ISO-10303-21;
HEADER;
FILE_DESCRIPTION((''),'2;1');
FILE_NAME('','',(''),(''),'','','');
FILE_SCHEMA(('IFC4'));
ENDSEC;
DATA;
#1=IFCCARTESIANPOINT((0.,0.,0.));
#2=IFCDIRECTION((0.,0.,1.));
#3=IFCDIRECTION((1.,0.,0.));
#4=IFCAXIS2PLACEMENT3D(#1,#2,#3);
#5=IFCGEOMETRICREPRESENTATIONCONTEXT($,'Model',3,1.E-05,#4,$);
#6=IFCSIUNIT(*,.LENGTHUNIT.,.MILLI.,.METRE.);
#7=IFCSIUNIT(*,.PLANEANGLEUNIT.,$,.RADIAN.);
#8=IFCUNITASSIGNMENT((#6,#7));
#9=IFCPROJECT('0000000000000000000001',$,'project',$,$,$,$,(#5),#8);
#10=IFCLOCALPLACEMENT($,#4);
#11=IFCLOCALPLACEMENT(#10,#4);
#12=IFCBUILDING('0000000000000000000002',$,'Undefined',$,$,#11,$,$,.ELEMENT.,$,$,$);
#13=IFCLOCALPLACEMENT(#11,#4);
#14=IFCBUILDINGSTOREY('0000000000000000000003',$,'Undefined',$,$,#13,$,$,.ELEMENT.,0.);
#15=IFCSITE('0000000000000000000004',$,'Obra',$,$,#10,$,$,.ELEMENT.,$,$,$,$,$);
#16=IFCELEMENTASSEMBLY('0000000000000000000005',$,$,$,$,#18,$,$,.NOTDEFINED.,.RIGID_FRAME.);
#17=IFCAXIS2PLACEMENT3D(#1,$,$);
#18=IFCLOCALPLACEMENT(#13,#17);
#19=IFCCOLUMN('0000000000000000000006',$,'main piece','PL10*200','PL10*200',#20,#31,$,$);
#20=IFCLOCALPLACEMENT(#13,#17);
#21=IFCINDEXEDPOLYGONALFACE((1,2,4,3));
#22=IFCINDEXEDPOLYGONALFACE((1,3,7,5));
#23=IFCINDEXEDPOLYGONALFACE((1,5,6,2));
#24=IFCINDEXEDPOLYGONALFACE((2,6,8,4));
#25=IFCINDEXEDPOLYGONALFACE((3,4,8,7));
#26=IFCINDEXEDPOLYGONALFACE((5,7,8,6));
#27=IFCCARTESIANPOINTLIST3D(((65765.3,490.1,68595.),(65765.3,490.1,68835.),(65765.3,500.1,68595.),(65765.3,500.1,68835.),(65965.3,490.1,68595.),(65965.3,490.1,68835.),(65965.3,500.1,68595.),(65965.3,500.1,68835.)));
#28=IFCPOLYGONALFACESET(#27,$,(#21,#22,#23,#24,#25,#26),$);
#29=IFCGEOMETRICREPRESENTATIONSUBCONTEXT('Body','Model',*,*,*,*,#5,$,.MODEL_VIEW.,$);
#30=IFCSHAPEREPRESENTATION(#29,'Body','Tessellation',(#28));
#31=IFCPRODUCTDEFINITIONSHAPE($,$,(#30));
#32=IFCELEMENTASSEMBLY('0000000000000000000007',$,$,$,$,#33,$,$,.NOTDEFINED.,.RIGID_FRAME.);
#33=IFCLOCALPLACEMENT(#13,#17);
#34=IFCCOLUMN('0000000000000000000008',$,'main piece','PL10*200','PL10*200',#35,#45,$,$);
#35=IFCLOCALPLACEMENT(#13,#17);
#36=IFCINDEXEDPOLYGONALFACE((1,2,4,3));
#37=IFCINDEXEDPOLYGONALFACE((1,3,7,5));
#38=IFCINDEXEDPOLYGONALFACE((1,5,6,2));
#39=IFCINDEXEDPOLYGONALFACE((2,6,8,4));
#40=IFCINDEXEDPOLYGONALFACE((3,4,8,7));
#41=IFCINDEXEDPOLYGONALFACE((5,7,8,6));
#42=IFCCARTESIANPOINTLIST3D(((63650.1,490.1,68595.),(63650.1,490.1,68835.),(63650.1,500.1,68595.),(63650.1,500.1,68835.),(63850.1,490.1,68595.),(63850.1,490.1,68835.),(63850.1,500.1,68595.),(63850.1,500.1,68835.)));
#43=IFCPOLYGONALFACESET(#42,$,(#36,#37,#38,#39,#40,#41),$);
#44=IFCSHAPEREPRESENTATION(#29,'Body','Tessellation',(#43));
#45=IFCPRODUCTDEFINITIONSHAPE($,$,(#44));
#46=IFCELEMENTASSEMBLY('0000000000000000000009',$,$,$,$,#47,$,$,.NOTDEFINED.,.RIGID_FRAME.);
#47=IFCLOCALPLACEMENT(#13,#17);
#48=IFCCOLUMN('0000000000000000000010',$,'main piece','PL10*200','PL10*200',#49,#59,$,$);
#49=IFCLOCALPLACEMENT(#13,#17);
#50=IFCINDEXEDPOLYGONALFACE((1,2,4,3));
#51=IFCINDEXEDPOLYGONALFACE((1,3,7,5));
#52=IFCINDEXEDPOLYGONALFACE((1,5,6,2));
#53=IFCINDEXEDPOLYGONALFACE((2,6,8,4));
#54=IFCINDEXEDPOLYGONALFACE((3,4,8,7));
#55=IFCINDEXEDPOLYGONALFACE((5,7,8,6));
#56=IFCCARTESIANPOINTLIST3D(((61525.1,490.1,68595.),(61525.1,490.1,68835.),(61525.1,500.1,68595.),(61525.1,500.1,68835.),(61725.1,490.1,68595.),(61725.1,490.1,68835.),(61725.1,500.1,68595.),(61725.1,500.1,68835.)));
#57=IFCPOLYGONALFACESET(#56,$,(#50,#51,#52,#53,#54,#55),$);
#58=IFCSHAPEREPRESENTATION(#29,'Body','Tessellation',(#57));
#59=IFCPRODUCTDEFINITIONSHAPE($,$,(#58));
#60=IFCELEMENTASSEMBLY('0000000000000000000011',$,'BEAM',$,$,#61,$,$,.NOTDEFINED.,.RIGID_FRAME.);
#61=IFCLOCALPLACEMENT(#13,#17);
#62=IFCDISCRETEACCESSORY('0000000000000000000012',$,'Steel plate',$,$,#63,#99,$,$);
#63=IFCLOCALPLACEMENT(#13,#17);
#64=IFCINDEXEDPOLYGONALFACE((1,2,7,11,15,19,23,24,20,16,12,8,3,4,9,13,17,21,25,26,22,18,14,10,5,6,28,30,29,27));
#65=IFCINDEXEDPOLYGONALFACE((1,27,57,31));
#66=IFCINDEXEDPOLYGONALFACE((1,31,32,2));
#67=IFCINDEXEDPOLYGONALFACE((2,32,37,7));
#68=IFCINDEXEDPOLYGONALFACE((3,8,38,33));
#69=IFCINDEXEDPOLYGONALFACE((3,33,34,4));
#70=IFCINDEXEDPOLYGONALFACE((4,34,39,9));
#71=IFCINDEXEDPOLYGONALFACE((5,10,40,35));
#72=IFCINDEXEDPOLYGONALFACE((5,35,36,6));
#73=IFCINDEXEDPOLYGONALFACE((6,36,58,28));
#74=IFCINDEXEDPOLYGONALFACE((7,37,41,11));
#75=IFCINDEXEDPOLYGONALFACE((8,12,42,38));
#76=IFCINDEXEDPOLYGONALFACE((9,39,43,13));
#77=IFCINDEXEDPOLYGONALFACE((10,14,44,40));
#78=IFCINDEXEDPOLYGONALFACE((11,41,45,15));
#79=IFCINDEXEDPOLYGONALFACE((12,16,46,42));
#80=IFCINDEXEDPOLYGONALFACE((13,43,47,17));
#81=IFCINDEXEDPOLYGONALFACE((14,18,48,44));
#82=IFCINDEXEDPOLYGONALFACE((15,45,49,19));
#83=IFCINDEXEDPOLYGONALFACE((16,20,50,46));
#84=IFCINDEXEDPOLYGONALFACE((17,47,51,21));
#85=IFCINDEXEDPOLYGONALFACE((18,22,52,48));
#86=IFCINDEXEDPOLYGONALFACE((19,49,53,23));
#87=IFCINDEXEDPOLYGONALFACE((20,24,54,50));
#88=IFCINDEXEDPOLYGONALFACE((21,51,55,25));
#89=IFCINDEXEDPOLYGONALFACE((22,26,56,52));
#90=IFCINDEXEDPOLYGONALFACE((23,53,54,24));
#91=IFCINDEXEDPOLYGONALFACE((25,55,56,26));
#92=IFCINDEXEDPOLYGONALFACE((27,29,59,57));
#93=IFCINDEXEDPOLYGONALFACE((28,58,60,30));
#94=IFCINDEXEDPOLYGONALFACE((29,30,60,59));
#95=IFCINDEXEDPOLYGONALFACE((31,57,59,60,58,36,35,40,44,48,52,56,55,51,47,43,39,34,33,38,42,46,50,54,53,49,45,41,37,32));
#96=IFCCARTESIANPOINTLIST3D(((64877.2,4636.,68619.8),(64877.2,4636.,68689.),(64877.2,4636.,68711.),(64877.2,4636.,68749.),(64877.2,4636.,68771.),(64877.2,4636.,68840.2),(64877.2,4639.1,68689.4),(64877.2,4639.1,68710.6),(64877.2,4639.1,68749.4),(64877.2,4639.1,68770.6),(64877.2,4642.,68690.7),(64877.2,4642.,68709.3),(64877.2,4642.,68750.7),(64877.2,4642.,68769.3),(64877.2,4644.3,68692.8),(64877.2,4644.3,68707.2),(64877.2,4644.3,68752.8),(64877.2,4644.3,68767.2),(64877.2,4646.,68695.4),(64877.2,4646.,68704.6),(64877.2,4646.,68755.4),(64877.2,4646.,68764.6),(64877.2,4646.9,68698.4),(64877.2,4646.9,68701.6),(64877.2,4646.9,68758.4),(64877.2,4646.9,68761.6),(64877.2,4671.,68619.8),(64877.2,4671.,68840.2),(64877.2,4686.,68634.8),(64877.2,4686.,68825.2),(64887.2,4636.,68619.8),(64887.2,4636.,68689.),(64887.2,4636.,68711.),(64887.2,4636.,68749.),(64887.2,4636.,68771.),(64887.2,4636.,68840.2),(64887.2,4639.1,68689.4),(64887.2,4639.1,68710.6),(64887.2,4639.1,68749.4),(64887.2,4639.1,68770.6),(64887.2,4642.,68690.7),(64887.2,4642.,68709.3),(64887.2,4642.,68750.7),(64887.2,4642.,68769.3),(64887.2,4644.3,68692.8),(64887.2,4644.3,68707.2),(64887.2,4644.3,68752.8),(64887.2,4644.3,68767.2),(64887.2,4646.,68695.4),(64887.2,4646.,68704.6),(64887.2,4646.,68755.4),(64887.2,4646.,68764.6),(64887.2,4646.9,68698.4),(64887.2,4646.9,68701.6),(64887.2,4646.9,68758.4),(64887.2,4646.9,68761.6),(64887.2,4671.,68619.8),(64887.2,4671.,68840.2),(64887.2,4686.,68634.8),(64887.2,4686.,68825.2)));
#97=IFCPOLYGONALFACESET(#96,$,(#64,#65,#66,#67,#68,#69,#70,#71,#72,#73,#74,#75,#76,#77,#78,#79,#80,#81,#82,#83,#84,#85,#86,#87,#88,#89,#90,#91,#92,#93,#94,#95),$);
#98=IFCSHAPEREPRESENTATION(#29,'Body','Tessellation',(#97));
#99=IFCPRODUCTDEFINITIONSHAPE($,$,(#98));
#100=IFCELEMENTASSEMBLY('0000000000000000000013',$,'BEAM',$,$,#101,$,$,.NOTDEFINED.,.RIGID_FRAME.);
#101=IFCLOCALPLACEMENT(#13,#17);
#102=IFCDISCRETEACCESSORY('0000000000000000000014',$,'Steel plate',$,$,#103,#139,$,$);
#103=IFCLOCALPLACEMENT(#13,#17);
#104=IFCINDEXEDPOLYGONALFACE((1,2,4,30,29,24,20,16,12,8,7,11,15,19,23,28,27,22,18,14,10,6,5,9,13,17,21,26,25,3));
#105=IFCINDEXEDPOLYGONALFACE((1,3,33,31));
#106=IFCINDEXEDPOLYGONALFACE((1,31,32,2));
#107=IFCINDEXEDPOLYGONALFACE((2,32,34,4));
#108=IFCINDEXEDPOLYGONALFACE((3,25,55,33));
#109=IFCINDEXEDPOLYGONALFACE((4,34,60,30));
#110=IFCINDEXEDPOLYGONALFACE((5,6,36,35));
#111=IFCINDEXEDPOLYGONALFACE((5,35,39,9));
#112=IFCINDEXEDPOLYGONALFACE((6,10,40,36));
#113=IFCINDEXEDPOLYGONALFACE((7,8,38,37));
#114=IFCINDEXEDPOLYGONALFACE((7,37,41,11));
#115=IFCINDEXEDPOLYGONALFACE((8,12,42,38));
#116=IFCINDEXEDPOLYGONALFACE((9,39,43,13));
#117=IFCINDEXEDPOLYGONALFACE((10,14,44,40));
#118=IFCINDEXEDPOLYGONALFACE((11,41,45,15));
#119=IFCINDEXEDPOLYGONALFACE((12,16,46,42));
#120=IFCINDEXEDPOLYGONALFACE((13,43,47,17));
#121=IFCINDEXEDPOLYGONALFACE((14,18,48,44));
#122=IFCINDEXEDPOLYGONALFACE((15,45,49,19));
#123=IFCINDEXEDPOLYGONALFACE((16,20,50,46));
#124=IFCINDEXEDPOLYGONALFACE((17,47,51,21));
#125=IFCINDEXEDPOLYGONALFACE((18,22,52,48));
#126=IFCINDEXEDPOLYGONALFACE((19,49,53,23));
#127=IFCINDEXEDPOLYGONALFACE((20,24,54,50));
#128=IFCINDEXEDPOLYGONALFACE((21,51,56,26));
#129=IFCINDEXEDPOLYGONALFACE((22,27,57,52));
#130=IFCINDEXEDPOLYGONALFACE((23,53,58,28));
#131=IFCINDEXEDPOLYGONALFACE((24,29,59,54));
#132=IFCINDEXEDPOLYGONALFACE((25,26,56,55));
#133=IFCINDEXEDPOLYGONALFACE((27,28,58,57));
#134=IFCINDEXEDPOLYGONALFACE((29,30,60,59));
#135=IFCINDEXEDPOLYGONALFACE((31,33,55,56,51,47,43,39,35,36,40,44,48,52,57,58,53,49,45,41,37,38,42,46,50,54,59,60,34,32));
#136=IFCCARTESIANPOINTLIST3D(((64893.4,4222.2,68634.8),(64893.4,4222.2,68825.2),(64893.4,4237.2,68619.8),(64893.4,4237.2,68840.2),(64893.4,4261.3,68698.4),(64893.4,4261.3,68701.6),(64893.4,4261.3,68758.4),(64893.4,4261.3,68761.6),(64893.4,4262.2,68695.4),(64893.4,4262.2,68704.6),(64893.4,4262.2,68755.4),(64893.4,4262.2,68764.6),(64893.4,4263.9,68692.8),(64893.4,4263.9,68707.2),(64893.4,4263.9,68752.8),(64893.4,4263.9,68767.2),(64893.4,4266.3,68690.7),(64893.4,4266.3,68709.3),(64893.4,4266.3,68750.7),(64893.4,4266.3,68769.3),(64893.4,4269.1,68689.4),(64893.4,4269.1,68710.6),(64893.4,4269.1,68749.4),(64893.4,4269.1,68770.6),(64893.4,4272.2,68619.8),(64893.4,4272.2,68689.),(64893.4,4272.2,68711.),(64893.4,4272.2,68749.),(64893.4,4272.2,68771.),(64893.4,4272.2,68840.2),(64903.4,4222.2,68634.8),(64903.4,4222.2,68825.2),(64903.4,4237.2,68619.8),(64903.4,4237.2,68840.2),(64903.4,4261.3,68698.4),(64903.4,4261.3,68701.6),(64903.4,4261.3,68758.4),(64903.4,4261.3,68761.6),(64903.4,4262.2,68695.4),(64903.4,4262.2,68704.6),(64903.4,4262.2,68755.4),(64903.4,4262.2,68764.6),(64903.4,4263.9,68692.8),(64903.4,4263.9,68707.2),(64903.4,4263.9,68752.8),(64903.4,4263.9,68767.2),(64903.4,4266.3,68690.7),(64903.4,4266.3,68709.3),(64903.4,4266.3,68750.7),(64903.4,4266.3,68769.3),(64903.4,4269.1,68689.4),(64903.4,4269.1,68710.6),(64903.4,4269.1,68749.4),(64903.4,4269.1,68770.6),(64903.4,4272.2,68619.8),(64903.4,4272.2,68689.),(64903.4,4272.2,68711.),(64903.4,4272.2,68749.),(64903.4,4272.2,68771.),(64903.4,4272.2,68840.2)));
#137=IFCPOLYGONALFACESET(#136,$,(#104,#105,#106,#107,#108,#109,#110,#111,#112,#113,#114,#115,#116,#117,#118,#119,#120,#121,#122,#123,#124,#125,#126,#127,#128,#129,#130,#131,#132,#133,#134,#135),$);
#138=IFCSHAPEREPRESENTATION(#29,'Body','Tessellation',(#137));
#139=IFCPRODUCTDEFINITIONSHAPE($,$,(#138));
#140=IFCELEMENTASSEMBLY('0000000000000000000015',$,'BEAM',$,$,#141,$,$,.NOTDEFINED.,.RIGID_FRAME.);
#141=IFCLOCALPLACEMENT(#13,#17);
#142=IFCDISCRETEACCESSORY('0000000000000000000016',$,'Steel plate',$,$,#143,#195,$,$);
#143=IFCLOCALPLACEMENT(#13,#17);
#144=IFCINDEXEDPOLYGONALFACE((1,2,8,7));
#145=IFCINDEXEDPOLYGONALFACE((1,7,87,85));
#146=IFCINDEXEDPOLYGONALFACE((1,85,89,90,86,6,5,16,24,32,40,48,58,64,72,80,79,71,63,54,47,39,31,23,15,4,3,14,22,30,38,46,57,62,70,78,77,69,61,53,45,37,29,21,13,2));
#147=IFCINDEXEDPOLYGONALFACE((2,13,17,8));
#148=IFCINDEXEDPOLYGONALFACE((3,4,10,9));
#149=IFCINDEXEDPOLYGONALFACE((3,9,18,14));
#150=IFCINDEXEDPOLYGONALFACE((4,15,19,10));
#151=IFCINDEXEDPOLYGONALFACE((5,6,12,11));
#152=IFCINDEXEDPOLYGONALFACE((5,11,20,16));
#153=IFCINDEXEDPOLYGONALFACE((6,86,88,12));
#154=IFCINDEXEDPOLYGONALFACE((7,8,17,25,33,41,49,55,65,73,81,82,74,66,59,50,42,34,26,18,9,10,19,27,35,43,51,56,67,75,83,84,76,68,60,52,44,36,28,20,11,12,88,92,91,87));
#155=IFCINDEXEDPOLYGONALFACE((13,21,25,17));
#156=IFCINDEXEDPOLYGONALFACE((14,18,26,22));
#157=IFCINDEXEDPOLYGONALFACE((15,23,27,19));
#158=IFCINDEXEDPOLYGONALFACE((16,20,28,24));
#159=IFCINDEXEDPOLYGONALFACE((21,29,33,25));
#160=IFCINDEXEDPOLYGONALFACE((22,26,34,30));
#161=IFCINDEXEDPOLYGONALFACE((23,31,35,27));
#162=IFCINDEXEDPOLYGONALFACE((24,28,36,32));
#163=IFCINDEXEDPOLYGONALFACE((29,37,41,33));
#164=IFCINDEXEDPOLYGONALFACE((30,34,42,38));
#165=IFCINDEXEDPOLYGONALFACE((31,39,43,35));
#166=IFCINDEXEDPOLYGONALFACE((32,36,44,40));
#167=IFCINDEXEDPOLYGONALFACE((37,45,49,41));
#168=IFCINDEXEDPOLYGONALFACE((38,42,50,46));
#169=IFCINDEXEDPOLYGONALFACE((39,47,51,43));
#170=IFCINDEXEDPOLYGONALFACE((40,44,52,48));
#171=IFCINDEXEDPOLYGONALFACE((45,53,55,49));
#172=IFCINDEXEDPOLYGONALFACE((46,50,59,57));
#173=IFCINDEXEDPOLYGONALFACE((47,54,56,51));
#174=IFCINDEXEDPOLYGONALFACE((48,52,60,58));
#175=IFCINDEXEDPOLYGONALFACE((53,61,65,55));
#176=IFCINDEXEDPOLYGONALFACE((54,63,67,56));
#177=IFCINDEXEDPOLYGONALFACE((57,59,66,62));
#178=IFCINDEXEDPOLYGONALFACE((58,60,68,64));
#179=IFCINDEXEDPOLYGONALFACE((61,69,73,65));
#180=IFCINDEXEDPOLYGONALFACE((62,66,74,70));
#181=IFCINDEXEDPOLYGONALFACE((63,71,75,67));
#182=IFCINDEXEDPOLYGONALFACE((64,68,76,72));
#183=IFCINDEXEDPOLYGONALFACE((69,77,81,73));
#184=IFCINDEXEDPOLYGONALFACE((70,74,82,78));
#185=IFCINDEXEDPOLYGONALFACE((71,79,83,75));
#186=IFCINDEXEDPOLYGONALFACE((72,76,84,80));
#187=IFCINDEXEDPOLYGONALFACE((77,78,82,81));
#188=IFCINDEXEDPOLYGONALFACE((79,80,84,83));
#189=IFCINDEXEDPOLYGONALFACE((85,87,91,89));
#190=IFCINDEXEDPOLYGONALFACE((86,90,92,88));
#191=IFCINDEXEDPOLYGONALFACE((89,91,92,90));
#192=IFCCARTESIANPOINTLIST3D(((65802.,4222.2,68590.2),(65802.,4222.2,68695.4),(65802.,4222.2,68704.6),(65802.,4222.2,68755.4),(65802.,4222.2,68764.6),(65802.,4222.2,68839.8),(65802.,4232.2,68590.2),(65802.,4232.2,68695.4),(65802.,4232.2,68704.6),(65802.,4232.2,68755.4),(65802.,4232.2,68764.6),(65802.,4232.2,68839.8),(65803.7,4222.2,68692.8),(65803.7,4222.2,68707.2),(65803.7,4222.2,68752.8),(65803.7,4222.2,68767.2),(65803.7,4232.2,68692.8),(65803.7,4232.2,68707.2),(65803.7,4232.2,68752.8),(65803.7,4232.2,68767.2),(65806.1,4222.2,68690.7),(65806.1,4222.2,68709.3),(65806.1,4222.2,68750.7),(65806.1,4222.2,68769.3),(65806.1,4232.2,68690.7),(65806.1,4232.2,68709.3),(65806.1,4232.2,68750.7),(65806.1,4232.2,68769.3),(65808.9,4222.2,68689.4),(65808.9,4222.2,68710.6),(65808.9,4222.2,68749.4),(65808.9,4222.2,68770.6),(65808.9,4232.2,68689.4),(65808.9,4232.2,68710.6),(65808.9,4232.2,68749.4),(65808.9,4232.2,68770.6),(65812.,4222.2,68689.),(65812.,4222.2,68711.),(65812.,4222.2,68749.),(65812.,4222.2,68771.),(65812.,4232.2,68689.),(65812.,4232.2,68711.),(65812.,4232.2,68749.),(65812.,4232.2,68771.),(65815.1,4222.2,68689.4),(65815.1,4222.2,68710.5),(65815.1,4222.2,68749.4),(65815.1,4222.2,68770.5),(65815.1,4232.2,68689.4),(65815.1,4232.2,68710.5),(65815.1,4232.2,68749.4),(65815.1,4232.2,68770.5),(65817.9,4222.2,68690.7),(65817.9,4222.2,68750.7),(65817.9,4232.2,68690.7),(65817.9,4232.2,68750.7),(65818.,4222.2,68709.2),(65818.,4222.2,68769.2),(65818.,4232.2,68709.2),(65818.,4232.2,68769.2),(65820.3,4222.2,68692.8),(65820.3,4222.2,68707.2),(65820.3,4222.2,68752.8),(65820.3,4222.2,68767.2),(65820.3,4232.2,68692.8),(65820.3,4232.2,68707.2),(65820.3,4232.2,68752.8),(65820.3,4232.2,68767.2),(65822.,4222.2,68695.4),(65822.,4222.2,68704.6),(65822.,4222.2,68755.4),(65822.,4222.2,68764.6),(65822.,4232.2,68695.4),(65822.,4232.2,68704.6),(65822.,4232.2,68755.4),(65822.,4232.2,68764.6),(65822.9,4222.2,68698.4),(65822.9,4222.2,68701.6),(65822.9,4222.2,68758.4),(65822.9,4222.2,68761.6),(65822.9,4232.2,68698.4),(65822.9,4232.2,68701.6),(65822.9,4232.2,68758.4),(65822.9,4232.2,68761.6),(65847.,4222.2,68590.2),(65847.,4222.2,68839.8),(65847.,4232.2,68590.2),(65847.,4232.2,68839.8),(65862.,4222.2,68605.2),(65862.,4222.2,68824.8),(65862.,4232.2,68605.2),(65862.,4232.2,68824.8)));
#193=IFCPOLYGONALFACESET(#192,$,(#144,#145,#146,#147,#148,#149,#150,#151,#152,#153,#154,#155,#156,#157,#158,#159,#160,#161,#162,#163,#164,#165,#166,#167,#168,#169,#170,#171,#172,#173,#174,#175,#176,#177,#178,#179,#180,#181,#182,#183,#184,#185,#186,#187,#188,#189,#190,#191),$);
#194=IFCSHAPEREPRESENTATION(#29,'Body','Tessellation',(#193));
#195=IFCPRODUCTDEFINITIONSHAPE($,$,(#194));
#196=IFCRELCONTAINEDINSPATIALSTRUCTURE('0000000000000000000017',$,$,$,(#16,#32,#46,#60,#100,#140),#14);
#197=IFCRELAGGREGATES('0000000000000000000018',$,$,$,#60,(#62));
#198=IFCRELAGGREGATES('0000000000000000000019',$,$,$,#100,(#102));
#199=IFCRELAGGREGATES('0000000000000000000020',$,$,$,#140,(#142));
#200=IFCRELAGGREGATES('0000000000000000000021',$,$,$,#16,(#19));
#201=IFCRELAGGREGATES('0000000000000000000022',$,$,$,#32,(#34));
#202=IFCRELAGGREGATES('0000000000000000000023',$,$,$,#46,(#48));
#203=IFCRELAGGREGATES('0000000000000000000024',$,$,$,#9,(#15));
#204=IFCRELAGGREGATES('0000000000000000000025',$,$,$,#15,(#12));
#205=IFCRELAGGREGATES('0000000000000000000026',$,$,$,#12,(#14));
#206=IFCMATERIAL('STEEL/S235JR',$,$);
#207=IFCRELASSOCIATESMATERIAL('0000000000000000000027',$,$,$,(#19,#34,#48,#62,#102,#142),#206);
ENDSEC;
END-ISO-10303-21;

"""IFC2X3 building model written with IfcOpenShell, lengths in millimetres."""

from ifc_helpers import new_model, si_unit, frame, origin_with_axes, origin_2d_with_axis, place, context, subcontext, project, spatial, polyline, rectangle, circle, outline, extrude, source, transform, mapped, material, element, aggregate, save


model = new_model("IFC2X3")

# Units and contexts
model_context = context("Model", 3, precision=1e-05, world=origin_with_axes())
body_context = subcontext(model_context, "Body", "Model", "MODEL_VIEW")
ifc_project = project(units=[si_unit("LENGTHUNIT", "METRE", prefix="MILLI"), si_unit("PLANEANGLEUNIT", "RADIAN")], contexts=[model_context])

# Site, building, storey
site_placement = place(None, origin_with_axes())
site = spatial("IfcSite", under=ifc_project, at=site_placement, Name="Obra", CompositionType="ELEMENT")
building_placement = place(site_placement, origin_with_axes())
building = spatial("IfcBuilding", under=site, at=building_placement, Name="Undefined", CompositionType="ELEMENT")
storey_placement = place(building_placement, origin_with_axes())
storey = spatial("IfcBuildingStorey", under=building, at=storey_placement, Name="Undefined", CompositionType="ELEMENT", Elevation=0.0)

# Element assemblies, columns
assembly_1_placement = place(storey_placement, origin_with_axes())
assembly_1 = element("IfcElementAssembly", 1, at=assembly_1_placement, inside=storey, AssemblyPlace="NOTDEFINED", PredefinedType="RIGID_FRAME")
ifc_material = material(Name="STEEL/S235JR")
column_1_placement = place(assembly_1_placement, frame((65865.3, 495.1, 68595.0), z_axis=(0.0, 0.0, 1.0), x_axis=(1.0, 0.000001, 0.0)))
column_1 = element("IfcColumn", 2, at=column_1_placement, material=ifc_material, Name="main piece", Description="PL10*200", ObjectType="PL10*200", context=body_context, shape_type="SweptSolid", body=[
    extrude(rectangle(XDim=10.0, YDim=200.0, at=origin_2d_with_axis()), frame((0.0, 0.0, 240.0), z_axis=(0.0, 0.0, -1.0), x_axis=(0.0, 1.0, 0.0)), (0.0, 0.0, 1.0), 240.0),
])
assembly_2_placement = place(storey_placement, origin_with_axes())
assembly_2 = element("IfcElementAssembly", 3, at=assembly_2_placement, inside=storey, AssemblyPlace="NOTDEFINED", PredefinedType="RIGID_FRAME")
column_2_placement = place(assembly_2_placement, frame((63750.1, 495.1, 68595.0), z_axis=(0.0, 0.0, 1.0), x_axis=(1.0, 0.000001, 0.0)))
column_2 = element("IfcColumn", 4, at=column_2_placement, material=ifc_material, Name="main piece", Description="PL10*200", ObjectType="PL10*200", context=body_context, shape_type="SweptSolid", body=[
    extrude(rectangle(XDim=10.0, YDim=200.0, at=origin_2d_with_axis()), frame((0.0, 0.0, 240.0), z_axis=(0.0, 0.0, -1.0), x_axis=(0.0, 1.0, 0.0)), (0.0, 0.0, 1.0), 240.0),
])
assembly_3_placement = place(storey_placement, origin_with_axes())
assembly_3 = element("IfcElementAssembly", 5, at=assembly_3_placement, inside=storey, AssemblyPlace="NOTDEFINED", PredefinedType="RIGID_FRAME")
column_3_placement = place(assembly_3_placement, frame((61625.1, 495.1, 68595.0), z_axis=(0.0, 0.0, 1.0), x_axis=(1.0, 0.000001, 0.0)))
column_3 = element("IfcColumn", 6, at=column_3_placement, material=ifc_material, Name="main piece", Description="PL10*200", ObjectType="PL10*200", context=body_context, shape_type="SweptSolid", body=[
    extrude(rectangle(XDim=10.0, YDim=200.0, at=origin_2d_with_axis()), frame((0.0, 0.0, 240.0), z_axis=(0.0, 0.0, -1.0), x_axis=(0.0, 1.0, 0.0)), (0.0, 0.0, 1.0), 240.0),
])

# Element assemblies, discrete accessories, openings
assembly_4_placement = place(storey_placement, origin_with_axes())
assembly_4 = element("IfcElementAssembly", 7, at=assembly_4_placement, inside=storey, Name="BEAM", AssemblyPlace="NOTDEFINED", PredefinedType="RIGID_FRAME")
discrete_accessory_1_placement = place(assembly_4_placement, frame((64882.2, 4636.0, 68619.8), z_axis=(1.0, 0.0, 0.0), x_axis=(0.0, 1.0, 0.0)))
discrete_accessory_1 = element("IfcDiscreteAccessory", 8, at=discrete_accessory_1_placement, material=ifc_material, Name="Steel plate", context=body_context, shape_type="SweptSolid", body=[
    extrude(outline(polyline([(0.0, 0.0), (35.0, 0.0), (50.0, 15.0), (50.0, 205.4), (35.0, 220.4), (0.0, 220.4), (0.0, 0.0)])), frame((0.0, 0.0, -5.0), z_axis=(0.0, 0.0, 1.0), x_axis=(1.0, 0.0, 0.0)), (0.0, 0.0, 1.0), 10.0),
])
shared_shape_1 = source(origin_with_axes(), body_context, "Body", "SweptSolid", [
    extrude(circle(Radius=11.0, at=origin_2d_with_axis()), frame((0.0, -13.2, 0.0), z_axis=(0.0, 1.0, 0.0), x_axis=(1.0, 0.0, 0.0)), (0.0, 0.0, 1.0), 10.2),
])
opening_1_placement = place(assembly_4_placement, frame((64890.3, 4676.0, 68850.0), z_axis=(0.0, -1.0, 0.0), x_axis=(0.0, 0.0, -1.0)))
element("IfcOpeningElement", 9, at=opening_1_placement, cuts=discrete_accessory_1, ObjectType="Opening", context=body_context, shape_type="MappedRepresentation", body=[
    mapped(shared_shape_1, transform((90.0, 0.0, 40.0))),
    mapped(shared_shape_1, transform((150.0, 0.0, 40.0))),
])
aggregate(assembly_4, [discrete_accessory_1])
assembly_5_placement = place(storey_placement, origin_with_axes())
assembly_5 = element("IfcElementAssembly", 10, at=assembly_5_placement, inside=storey, Name="BEAM", AssemblyPlace="NOTDEFINED", PredefinedType="RIGID_FRAME")
discrete_accessory_2_placement = place(assembly_5_placement, frame((64898.4, 4272.2, 68619.8), z_axis=(-1.0, 0.0, 0.0), x_axis=(0.0, -1.0, 0.0)))
discrete_accessory_2 = element("IfcDiscreteAccessory", 11, at=discrete_accessory_2_placement, material=ifc_material, Name="Steel plate", context=body_context, shape_type="SweptSolid", body=[
    extrude(outline(polyline([(0.0, 0.0), (35.0, 0.0), (50.0, 15.0), (50.0, 205.4), (35.0, 220.4), (0.0, 220.4), (0.0, 0.0)])), frame((0.0, 0.0, -5.0), z_axis=(0.0, 0.0, 1.0), x_axis=(1.0, 0.0, 0.0)), (0.0, 0.0, 1.0), 10.0),
])
opening_2_placement = place(assembly_5_placement, frame((64890.3, 4232.2, 68850.0), z_axis=(0.0, 1.0, 0.0), x_axis=(0.0, 0.0, -1.0)))
element("IfcOpeningElement", 12, at=opening_2_placement, cuts=discrete_accessory_2, ObjectType="Opening", context=body_context, shape_type="MappedRepresentation", body=[
    mapped(shared_shape_1, transform((90.0, 0.0, 40.0))),
    mapped(shared_shape_1, transform((150.0, 0.0, 40.0))),
])
aggregate(assembly_5, [discrete_accessory_2])

# Element assembly, discrete accessory, opening
assembly_6_placement = place(storey_placement, origin_with_axes())
assembly_6 = element("IfcElementAssembly", 13, at=assembly_6_placement, inside=storey, Name="BEAM", AssemblyPlace="NOTDEFINED", PredefinedType="RIGID_FRAME")
discrete_accessory_3_placement = place(assembly_6_placement, frame((65802.0, 4227.2, 68590.2), z_axis=(0.0, -1.0, 0.0), x_axis=(1.0, 0.0, 0.0)))
discrete_accessory_3 = element("IfcDiscreteAccessory", 14, at=discrete_accessory_3_placement, material=ifc_material, Name="Steel plate", context=body_context, shape_type="SweptSolid", body=[
    extrude(outline(polyline([(0.0, 0.0), (45.0, 0.0), (60.0, 15.0), (60.0, 234.6), (45.0, 249.6), (0.0, 249.6), (0.0, 0.0)])), frame((0.0, 0.0, -5.0), z_axis=(0.0, 0.0, 1.0), x_axis=(1.0, 0.0, 0.0)), (0.0, 0.0, 1.0), 10.0),
])
opening_3_placement = place(assembly_6_placement, frame((65852.0, 4219.1, 68850.0), z_axis=(-1.0, 0.0, 0.0), x_axis=(0.0, 0.0, -1.0)))
element("IfcOpeningElement", 15, at=opening_3_placement, cuts=discrete_accessory_3, ObjectType="Opening", context=body_context, shape_type="MappedRepresentation", body=[
    mapped(shared_shape_1, transform((90.0, 0.0, 40.0))),
    mapped(shared_shape_1, transform((150.0, 0.0, 40.0))),
])
aggregate(assembly_6, [discrete_accessory_3])

aggregate(assembly_1, [column_1])
aggregate(assembly_2, [column_2])
aggregate(assembly_3, [column_3])

save(model, "model.ifc")
